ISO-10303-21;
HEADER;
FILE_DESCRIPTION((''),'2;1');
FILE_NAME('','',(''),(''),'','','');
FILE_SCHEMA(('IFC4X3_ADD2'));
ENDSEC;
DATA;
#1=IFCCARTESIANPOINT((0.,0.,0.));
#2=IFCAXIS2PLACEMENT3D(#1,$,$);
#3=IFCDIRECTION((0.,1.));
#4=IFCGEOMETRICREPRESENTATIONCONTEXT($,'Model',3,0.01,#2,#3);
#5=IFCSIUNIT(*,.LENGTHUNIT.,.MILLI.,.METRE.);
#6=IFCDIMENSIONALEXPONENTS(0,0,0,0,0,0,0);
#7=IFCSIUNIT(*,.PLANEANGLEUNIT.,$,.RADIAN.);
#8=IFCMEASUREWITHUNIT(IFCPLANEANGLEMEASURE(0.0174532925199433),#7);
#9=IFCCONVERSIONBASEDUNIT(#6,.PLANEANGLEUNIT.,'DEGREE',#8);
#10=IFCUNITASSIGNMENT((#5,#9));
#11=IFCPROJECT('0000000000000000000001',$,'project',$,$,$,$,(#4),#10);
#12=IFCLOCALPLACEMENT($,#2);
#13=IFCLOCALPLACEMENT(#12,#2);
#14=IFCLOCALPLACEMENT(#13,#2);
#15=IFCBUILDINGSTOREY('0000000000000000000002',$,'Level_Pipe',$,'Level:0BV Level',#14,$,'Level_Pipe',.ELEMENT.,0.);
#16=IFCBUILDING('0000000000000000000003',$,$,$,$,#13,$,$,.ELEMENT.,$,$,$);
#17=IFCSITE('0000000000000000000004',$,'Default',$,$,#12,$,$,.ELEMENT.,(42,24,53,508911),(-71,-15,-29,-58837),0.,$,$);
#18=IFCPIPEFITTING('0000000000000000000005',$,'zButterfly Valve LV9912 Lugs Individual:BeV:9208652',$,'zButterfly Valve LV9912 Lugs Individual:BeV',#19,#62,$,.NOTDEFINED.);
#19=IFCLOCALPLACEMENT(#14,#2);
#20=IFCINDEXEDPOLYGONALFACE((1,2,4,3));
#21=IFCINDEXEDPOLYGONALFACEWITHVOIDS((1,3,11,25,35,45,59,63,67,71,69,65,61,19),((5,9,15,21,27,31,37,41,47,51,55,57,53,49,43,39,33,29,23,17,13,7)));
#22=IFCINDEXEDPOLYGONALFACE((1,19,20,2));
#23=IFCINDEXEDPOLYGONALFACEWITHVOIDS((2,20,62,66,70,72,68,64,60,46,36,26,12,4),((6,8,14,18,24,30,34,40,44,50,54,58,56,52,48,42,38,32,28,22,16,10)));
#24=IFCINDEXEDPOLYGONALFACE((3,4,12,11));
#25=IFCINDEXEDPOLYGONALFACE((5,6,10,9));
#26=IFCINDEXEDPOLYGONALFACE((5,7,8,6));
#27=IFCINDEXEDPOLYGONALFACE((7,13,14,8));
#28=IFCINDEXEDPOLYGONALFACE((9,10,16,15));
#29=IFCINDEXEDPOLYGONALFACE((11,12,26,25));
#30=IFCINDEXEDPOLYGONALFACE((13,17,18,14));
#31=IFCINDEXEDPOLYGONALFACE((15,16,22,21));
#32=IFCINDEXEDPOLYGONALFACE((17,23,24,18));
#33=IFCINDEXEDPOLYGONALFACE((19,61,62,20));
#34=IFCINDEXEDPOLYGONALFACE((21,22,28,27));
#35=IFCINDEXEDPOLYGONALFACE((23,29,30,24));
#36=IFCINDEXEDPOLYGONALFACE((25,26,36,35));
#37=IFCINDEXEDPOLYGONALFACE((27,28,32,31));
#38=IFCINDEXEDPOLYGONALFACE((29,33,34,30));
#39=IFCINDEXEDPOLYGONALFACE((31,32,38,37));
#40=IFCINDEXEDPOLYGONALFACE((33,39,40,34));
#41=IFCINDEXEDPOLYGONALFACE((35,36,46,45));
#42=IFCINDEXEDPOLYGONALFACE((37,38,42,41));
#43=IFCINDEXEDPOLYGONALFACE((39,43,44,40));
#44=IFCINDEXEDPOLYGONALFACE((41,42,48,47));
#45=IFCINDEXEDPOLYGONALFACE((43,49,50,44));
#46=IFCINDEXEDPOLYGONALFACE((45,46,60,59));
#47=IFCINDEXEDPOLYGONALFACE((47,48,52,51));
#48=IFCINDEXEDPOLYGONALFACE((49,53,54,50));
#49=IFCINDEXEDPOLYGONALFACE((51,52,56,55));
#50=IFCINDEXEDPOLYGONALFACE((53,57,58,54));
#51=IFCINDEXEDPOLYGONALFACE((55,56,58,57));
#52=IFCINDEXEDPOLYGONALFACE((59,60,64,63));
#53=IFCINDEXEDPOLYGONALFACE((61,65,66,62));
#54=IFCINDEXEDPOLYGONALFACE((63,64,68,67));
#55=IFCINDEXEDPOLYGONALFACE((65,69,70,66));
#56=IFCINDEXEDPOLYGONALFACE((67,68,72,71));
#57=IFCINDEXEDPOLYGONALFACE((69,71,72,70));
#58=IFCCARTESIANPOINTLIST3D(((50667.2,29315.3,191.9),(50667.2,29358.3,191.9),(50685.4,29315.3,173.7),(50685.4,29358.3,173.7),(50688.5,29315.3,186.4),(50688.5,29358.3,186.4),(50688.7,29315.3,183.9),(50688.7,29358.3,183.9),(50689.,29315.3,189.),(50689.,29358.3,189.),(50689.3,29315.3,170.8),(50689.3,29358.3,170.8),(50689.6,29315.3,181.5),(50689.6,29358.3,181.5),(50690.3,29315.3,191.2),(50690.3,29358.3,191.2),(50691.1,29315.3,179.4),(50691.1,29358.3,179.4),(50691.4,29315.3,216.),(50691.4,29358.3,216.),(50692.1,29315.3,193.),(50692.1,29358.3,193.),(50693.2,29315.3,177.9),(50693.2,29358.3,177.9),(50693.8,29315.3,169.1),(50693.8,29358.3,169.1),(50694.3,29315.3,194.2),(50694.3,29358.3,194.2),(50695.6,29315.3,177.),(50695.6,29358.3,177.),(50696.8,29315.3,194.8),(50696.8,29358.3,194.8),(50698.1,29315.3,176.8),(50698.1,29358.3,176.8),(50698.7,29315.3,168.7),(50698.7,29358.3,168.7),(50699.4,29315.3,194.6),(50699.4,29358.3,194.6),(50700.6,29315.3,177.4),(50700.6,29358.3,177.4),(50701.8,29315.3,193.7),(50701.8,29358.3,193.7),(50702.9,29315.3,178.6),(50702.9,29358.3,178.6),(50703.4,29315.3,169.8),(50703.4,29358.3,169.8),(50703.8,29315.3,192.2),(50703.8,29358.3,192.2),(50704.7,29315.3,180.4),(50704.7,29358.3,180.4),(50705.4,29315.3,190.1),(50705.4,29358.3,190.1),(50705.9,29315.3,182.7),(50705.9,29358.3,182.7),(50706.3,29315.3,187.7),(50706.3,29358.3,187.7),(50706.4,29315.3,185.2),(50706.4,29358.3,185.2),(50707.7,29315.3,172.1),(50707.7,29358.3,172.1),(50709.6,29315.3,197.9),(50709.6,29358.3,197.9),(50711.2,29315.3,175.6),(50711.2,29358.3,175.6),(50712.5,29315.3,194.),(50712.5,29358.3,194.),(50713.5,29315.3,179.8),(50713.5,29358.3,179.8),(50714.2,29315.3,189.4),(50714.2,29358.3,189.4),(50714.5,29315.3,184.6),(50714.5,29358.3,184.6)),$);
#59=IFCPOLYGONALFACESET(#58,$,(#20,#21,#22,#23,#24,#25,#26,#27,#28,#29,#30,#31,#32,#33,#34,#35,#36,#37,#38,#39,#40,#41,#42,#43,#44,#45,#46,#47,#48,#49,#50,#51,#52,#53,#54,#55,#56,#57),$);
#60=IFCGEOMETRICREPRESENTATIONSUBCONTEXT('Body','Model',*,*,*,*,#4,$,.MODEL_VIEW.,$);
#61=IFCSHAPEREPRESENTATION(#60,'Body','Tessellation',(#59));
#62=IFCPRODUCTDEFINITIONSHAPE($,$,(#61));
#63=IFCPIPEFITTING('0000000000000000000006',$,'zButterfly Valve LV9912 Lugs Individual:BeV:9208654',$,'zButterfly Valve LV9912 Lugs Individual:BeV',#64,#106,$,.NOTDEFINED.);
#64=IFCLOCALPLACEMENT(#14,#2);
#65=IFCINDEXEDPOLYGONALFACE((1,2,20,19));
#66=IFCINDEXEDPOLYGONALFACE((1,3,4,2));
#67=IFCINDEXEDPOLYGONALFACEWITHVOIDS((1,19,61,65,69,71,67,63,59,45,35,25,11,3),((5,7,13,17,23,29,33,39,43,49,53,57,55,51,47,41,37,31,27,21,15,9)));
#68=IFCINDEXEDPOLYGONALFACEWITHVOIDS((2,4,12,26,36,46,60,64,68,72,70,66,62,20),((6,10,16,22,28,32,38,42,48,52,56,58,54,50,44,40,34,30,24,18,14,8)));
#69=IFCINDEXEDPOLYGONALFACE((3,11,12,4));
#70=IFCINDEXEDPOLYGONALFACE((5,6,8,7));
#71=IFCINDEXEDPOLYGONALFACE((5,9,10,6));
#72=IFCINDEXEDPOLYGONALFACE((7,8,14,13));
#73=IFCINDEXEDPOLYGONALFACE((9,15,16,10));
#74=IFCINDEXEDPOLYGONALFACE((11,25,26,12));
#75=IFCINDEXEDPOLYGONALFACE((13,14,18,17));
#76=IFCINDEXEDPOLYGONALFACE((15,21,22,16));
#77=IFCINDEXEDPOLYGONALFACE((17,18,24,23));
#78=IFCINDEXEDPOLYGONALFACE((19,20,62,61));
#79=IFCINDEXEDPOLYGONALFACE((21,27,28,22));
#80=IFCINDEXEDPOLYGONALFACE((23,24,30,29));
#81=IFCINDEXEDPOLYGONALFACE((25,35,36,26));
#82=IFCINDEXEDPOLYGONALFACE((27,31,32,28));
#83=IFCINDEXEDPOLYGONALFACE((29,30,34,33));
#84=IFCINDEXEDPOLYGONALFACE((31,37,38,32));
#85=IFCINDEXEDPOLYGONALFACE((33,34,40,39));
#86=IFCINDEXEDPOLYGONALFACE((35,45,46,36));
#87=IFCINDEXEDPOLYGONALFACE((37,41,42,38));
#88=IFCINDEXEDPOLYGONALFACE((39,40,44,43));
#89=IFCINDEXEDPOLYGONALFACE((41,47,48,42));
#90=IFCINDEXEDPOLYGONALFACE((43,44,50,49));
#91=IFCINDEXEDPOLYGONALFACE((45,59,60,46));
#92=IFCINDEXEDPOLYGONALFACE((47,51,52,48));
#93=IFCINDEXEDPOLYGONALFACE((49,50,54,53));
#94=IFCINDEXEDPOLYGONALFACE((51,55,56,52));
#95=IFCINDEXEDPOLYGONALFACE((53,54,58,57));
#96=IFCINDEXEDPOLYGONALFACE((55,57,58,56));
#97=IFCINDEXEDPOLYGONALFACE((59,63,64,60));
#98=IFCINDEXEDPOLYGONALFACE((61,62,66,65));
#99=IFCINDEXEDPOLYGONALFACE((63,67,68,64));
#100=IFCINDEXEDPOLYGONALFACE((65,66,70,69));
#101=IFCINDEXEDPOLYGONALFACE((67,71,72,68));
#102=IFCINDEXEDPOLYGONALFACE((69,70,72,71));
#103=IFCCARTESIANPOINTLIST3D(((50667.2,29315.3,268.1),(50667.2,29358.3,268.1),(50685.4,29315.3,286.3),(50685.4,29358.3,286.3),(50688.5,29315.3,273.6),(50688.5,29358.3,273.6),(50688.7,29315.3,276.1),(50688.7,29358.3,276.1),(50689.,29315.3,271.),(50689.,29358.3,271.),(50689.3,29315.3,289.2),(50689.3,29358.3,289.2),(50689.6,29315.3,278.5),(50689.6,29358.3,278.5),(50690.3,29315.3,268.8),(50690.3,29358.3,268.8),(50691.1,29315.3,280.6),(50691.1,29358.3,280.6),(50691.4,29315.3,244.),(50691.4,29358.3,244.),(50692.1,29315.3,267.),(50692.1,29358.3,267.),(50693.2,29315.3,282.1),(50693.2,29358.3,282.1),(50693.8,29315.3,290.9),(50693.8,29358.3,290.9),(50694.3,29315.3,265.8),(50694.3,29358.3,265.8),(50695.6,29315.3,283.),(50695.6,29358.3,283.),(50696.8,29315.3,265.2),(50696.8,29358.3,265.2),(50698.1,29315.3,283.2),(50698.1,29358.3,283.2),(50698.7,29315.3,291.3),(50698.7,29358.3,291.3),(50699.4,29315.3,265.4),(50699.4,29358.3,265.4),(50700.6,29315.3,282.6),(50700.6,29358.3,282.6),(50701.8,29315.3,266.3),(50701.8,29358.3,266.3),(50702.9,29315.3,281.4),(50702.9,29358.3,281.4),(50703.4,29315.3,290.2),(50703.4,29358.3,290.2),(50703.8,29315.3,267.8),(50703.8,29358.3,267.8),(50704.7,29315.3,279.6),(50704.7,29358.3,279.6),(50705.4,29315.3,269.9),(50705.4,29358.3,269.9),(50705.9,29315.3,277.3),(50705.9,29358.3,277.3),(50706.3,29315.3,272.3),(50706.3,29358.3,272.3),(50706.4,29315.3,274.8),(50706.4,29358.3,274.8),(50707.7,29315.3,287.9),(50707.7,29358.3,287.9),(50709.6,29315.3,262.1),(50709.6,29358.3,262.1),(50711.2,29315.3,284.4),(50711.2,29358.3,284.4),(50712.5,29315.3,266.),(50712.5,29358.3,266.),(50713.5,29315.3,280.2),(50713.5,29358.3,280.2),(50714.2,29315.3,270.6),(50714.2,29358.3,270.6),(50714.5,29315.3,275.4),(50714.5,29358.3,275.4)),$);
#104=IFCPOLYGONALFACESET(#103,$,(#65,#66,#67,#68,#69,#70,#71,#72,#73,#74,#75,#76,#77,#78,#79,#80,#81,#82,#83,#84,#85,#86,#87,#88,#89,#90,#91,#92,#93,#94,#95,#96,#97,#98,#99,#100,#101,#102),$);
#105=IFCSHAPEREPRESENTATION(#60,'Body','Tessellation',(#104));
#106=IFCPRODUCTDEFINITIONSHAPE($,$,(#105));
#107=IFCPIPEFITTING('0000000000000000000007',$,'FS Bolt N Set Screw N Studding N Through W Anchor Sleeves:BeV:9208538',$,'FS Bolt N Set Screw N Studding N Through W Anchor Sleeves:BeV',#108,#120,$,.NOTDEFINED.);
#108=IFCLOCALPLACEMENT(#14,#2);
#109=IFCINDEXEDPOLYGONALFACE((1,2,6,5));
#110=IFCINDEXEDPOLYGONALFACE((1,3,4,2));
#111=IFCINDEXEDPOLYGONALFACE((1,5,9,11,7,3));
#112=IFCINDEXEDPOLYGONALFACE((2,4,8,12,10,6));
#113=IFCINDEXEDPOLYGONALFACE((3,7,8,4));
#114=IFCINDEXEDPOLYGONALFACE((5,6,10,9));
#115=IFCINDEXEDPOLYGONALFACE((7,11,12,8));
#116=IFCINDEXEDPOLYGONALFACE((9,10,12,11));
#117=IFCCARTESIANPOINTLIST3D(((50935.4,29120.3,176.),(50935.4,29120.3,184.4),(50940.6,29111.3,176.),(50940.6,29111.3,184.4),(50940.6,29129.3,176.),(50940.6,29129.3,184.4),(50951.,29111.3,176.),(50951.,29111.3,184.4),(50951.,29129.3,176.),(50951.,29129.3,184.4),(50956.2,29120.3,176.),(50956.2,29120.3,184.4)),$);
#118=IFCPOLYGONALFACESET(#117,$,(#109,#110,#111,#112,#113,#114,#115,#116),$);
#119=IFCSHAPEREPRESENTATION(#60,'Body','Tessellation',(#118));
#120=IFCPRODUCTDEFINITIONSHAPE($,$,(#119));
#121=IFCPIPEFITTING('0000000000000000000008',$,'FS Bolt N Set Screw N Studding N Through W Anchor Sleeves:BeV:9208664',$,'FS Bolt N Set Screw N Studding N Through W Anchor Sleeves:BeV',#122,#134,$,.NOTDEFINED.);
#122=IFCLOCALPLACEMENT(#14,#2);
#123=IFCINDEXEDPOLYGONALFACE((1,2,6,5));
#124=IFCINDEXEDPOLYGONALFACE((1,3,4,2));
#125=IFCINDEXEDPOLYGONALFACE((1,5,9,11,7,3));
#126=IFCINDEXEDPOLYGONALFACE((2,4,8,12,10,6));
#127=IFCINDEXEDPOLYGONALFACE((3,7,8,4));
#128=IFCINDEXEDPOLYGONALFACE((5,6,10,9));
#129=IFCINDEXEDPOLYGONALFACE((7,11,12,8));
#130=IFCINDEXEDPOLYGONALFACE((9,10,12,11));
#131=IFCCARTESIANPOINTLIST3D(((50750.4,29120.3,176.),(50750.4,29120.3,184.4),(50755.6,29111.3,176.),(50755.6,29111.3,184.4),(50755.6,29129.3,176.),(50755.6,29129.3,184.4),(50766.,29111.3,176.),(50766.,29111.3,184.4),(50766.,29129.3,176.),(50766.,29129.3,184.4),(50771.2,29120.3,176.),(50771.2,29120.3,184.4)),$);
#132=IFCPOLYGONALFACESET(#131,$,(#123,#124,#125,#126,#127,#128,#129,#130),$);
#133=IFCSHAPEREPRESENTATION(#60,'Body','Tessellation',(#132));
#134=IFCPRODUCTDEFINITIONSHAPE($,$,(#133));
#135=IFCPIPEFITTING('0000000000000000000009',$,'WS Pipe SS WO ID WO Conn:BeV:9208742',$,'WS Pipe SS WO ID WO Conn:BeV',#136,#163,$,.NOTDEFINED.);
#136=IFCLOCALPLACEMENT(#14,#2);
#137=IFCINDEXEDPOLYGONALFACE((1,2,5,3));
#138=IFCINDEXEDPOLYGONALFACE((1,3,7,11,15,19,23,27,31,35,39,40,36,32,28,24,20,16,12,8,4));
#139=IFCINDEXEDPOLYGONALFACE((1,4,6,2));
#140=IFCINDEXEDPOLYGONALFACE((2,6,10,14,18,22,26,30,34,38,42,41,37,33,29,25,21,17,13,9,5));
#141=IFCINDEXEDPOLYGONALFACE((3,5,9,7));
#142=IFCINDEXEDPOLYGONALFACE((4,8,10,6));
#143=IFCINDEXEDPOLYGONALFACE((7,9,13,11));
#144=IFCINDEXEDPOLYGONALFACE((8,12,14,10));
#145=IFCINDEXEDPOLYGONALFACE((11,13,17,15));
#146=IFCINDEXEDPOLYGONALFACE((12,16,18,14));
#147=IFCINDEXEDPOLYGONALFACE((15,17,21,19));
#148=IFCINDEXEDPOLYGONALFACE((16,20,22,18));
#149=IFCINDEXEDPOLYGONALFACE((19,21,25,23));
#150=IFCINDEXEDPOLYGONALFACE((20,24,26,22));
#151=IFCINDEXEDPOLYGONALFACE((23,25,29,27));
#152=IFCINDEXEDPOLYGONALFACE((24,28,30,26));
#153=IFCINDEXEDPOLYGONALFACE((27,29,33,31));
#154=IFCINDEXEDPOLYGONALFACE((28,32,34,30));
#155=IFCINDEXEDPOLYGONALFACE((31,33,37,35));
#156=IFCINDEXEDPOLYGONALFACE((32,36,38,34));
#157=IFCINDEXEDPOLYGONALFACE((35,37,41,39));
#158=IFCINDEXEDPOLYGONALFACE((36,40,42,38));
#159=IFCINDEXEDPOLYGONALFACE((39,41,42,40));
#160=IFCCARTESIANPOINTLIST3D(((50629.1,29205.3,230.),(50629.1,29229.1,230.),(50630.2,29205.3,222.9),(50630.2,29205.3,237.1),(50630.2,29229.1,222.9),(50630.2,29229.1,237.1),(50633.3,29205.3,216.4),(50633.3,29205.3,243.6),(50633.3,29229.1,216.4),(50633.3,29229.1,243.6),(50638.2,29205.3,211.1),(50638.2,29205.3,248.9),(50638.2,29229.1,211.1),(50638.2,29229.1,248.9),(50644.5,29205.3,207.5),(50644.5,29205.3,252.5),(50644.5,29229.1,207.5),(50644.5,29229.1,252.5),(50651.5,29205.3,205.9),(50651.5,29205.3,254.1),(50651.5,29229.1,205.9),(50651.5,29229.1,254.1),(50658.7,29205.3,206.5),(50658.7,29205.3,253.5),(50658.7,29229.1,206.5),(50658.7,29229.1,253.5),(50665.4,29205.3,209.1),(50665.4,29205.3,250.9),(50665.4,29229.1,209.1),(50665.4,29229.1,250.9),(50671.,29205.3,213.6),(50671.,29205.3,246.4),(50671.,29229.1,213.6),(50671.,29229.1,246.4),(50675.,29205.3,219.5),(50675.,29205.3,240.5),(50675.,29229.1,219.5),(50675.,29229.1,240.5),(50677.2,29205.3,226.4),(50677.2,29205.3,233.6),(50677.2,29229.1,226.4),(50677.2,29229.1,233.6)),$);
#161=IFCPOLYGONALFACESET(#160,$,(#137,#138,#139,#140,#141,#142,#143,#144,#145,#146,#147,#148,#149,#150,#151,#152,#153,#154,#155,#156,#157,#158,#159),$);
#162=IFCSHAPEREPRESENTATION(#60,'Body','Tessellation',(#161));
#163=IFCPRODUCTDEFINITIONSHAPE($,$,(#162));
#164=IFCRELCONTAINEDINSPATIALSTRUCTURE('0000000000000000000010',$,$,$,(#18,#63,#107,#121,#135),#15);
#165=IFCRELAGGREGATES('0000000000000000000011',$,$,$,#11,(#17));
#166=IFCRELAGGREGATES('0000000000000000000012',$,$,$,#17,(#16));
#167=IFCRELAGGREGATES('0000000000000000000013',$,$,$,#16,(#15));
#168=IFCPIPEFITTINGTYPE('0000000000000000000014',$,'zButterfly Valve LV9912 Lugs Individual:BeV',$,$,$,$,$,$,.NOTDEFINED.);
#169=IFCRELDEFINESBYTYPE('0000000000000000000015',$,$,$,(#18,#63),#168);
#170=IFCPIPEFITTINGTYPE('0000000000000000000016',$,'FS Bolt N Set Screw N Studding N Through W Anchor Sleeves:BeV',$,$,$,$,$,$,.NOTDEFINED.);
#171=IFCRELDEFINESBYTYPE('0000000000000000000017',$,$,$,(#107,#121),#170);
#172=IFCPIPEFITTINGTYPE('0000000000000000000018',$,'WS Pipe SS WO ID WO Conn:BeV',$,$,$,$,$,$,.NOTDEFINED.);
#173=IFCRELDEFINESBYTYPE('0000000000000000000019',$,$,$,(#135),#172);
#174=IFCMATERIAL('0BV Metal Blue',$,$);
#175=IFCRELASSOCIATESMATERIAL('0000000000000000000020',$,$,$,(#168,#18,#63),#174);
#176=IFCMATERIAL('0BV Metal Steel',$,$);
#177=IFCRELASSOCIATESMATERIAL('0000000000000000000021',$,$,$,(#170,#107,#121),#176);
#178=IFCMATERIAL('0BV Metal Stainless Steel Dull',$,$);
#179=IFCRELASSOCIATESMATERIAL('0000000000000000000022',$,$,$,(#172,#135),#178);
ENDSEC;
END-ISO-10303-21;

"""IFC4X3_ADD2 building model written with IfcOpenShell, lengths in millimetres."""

from ifc_helpers import new_model, entity, si_unit, converted_unit, direction, frame, frame_2d, origin, place, context, subcontext, project, spatial, polyline, circle_curve, parameter, trimmed, segment, composite_curve, circle, outline, extrude, source, transform, mapped, material, type_object, type_shapes, element, save


model = new_model("IFC4X3_ADD2")

# Units and contexts
model_context = context("Model", 3, precision=0.01, world=origin(), true_north=direction((0.0, 1.0)))
body_context = subcontext(model_context, "Body", "Model", "MODEL_VIEW")
ifc_project = project(units=[si_unit("LENGTHUNIT", "METRE", prefix="MILLI"), converted_unit("PLANEANGLEUNIT", "DEGREE", entity("IfcPlaneAngleMeasure", 0.0174532925199433), si_unit("PLANEANGLEUNIT", "RADIAN"), dimensions=[0, 0, 0, 0, 0, 0, 0])], contexts=[model_context])

# Site, building, storey
site_placement = place(None, origin())
site = spatial("IfcSite", under=ifc_project, at=site_placement, Name="Default", CompositionType="ELEMENT", RefLatitude=(42, 24, 53, 508911), RefLongitude=(-71, -15, -29, -58837), RefElevation=0.0)
building_placement = place(site_placement, origin())
building = spatial("IfcBuilding", under=site, at=building_placement, CompositionType="ELEMENT")
storey_placement = place(building_placement, origin())
storey = spatial("IfcBuildingStorey", under=building, at=storey_placement, Name="Level_Pipe", ObjectType="Level:0BV Level", LongName="Level_Pipe", CompositionType="ELEMENT", Elevation=0.0)

# Pipe fittings
ifc_material_1 = material(Name="0BV Metal Stainless Steel Dull")
ifc_material_2 = material(Name="0BV Metal Blue")
pipe_fitting_type_1 = type_object("IfcPipeFittingType", Name="zButterfly Valve LV9912 Lugs Individual:BeV", PredefinedType="NOTDEFINED", material=ifc_material_2)
shared_shape_1 = source(origin(), body_context, "Body", "SweptSolid", [
    extrude(outline(composite_curve([segment(polyline([(-17.1, -12.8), (17.1, -12.8)]), True, "CONTINUOUS"), segment(polyline([(17.1, -12.8), (17.1, 12.8)]), True, "CONTINUOUS"), segment(trimmed(circle_curve(frame_2d((0.0, 12.8), x_axis=(1.0, 0.0)), 17.1), [parameter(360.0)], [parameter(180.0)], True, "PARAMETER"), True, "CONTINUOUS"), segment(polyline([(-17.1, 12.8), (-17.1, -12.8)]), True, "CONTINUOUS")], self_intersect=False), holes=[composite_curve([segment(trimmed(circle_curve(frame_2d((0.0, 12.8), x_axis=(1.0, 0.0)), 9.0), [parameter(0.0)], [parameter(180.0)], True, "PARAMETER"), False, "CONTINUOUS"), segment(trimmed(circle_curve(frame_2d((0.0, 12.8), x_axis=(1.0, 0.0)), 9.0), [parameter(180.0)], [parameter(0.0)], True, "PARAMETER"), False, "CONTINUOUS")], self_intersect=False)]), frame((0.0, -12.8, -21.5)), (0.0, 0.0, 1.0), 43.0),
])
type_shapes(pipe_fitting_type_1, [shared_shape_1])
for number, where, z_axis, x_axis, name in (
    (1, (50697.5, 29336.8, 185.8), (0.0, 1.0, 0.0), (0.707107, 0.0, 0.707107), "zButterfly Valve LV9912 Lugs Individual:BeV:9208652"),
    (2, (50697.5, 29336.8, 274.2), (0.0, 1.0, 0.0), (-0.707107, 0.0, 0.707107), "zButterfly Valve LV9912 Lugs Individual:BeV:9208654"),
):
    element("IfcPipeFitting", number, at=place(storey_placement, frame(where, z_axis=z_axis, x_axis=x_axis)), inside=storey, type_object=pipe_fitting_type_1, material=ifc_material_2, Name=name, ObjectType="zButterfly Valve LV9912 Lugs Individual:BeV", PredefinedType="NOTDEFINED", context=body_context, shape_type="MappedRepresentation", body=[
        mapped(shared_shape_1, transform((0.0, 0.0, 0.0), scale=1.0)),
    ])
ifc_material_3 = material(Name="0BV Metal Steel")
pipe_fitting_type_2 = type_object("IfcPipeFittingType", Name="FS Bolt N Set Screw N Studding N Through W Anchor Sleeves:BeV", PredefinedType="NOTDEFINED", material=ifc_material_3)
shared_shape_2 = source(origin(), body_context, "Body", "SweptSolid", [
    extrude(outline(polyline([(-5.2, -9.0), (5.2, -9.0), (10.4, 0.0), (5.2, 9.0), (-5.2, 9.0), (-10.4, 0.0), (-5.2, -9.0)])), frame((-8.4, 0.0, 0.0), z_axis=(1.0, 0.0, 0.0), x_axis=(0.0, -0.5, -0.866025)), (0.0, 0.0, 1.0), 8.4),
])
type_shapes(pipe_fitting_type_2, [shared_shape_2])
for number, where, z_axis, x_axis, name in (
    (3, (50945.8, 29120.3, 176.0), (0.0, 1.0, 0.0), (0.0, 0.0, -1.0), "FS Bolt N Set Screw N Studding N Through W Anchor Sleeves:BeV:9208538"),
    (4, (50760.8, 29120.3, 176.0), (0.0, 1.0, 0.0), (0.0, 0.0, -1.0), "FS Bolt N Set Screw N Studding N Through W Anchor Sleeves:BeV:9208664"),
):
    element("IfcPipeFitting", number, at=place(storey_placement, frame(where, z_axis=z_axis, x_axis=x_axis)), inside=storey, type_object=pipe_fitting_type_2, material=ifc_material_3, Name=name, ObjectType="FS Bolt N Set Screw N Studding N Through W Anchor Sleeves:BeV", PredefinedType="NOTDEFINED", context=body_context, shape_type="MappedRepresentation", body=[
        mapped(shared_shape_2, transform((0.0, 0.0, 0.0), scale=1.0)),
    ])
pipe_fitting_type_3 = type_object("IfcPipeFittingType", Name="WS Pipe SS WO ID WO Conn:BeV", PredefinedType="NOTDEFINED", material=ifc_material_1)
shared_shape_3 = source(origin(), body_context, "Body", "SweptSolid", [
    extrude(circle(Radius=24.1, at=frame_2d((0.0, 0.0), x_axis=(1.0, 0.0))), frame((-11.9, 0.0, 0.0), z_axis=(1.0, 0.0, 0.0), x_axis=(0.0, 1.0, 0.0)), (0.0, 0.0, 1.0), 23.8),
])
type_shapes(pipe_fitting_type_3, [shared_shape_3])
pipe_fitting_1_placement = place(storey_placement, frame((50653.3, 29217.2, 230.0), z_axis=(0.0, 0.0, 1.0), x_axis=(0.0, 1.0, 0.0)))
element("IfcPipeFitting", 5, at=pipe_fitting_1_placement, inside=storey, type_object=pipe_fitting_type_3, material=ifc_material_1, Name="WS Pipe SS WO ID WO Conn:BeV:9208742", ObjectType="WS Pipe SS WO ID WO Conn:BeV", PredefinedType="NOTDEFINED", context=body_context, shape_type="MappedRepresentation", body=[
    mapped(shared_shape_3, transform((0.0, 0.0, 0.0), scale=1.0)),
])

save(model, "model.ifc")
